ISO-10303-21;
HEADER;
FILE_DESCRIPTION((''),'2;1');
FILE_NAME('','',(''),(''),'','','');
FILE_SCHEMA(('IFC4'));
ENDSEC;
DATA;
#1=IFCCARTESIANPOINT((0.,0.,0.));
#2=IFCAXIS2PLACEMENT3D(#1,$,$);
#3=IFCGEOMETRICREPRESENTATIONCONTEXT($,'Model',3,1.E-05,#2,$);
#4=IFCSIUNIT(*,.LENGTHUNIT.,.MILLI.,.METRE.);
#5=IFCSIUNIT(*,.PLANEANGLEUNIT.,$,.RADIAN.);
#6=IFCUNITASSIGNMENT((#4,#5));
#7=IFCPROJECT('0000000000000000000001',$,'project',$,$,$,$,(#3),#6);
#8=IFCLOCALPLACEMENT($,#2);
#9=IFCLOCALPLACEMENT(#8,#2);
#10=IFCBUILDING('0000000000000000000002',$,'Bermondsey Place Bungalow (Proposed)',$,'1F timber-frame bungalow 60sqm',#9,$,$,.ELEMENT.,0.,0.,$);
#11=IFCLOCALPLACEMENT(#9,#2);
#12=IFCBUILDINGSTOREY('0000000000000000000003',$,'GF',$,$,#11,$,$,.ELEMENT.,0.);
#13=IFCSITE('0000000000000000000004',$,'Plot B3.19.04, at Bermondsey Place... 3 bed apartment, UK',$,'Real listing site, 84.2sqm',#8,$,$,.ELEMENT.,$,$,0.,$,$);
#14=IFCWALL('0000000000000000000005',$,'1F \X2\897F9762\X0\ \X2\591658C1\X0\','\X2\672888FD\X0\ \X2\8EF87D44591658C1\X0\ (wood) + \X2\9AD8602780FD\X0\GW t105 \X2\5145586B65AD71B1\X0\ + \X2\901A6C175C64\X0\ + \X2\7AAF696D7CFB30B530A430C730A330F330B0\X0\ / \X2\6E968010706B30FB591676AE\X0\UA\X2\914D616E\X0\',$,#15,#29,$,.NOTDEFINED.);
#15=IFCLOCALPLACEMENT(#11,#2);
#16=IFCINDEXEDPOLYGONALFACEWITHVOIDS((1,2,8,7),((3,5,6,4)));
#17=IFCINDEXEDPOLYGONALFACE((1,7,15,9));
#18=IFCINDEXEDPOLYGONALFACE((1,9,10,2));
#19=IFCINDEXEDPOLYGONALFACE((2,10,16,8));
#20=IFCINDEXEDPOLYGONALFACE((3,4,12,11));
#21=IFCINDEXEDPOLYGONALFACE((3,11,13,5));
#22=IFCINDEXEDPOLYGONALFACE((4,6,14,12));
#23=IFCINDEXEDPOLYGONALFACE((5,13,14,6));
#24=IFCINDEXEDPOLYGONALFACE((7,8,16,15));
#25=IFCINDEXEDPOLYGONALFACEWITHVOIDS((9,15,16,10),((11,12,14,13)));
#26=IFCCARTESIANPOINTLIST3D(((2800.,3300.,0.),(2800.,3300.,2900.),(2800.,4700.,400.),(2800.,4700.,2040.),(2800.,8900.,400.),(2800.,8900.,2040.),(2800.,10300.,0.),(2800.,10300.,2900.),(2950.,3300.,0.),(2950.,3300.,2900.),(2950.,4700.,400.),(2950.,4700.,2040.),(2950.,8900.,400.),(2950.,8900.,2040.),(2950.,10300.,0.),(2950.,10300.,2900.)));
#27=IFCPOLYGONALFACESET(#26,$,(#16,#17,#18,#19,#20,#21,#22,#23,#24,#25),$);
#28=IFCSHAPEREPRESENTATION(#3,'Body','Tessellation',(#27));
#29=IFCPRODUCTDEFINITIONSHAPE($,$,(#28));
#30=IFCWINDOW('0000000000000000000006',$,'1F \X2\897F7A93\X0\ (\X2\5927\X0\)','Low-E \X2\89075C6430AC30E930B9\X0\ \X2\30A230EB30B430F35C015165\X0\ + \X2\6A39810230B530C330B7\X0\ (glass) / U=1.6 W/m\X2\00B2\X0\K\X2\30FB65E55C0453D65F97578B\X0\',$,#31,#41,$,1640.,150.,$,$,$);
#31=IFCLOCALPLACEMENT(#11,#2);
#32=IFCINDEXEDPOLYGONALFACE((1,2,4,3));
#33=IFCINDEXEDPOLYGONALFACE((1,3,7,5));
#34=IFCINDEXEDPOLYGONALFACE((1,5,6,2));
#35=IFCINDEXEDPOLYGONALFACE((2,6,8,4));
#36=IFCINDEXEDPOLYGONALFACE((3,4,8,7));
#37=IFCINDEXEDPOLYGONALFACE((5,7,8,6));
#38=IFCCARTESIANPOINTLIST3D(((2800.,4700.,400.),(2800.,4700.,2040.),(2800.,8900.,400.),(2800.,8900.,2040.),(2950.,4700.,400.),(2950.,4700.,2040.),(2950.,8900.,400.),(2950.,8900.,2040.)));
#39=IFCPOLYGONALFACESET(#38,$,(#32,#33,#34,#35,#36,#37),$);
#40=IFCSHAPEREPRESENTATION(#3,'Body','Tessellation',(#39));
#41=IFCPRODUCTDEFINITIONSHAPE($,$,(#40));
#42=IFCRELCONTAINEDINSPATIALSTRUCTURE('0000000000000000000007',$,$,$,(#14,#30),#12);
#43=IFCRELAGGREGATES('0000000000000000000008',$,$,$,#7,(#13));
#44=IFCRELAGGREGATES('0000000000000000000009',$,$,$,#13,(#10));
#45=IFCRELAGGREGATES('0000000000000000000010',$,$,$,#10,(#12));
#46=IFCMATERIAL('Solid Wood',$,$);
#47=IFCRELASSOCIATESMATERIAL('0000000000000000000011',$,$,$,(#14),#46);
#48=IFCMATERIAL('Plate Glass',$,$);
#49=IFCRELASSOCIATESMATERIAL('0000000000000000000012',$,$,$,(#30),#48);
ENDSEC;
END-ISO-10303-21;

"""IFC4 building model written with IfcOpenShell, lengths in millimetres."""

from ifc_helpers import new_model, si_unit, frame, frame_2d, origin, place, context, project, spatial, rectangle, extrude, material, element, fill, save


model = new_model("IFC4")

# Units and contexts
model_context = context("Model", 3, precision=1e-05, world=origin())
ifc_project = project(units=[si_unit("LENGTHUNIT", "METRE", prefix="MILLI"), si_unit("PLANEANGLEUNIT", "RADIAN")], contexts=[model_context])

# Site, building, storey
site_placement = place(None, origin())
site = spatial("IfcSite", under=ifc_project, at=site_placement, Name="Plot B3.19.04, at Bermondsey Place... 3 bed apartment, UK", ObjectType="Real listing site, 84.2sqm", CompositionType="ELEMENT", RefElevation=0.0)
building_placement = place(site_placement, origin())
building = spatial("IfcBuilding", under=site, at=building_placement, Name="Bermondsey Place Bungalow (Proposed)", ObjectType="1F timber-frame bungalow 60sqm", CompositionType="ELEMENT", ElevationOfRefHeight=0.0, ElevationOfTerrain=0.0)
storey_placement = place(building_placement, origin())
storey = spatial("IfcBuildingStorey", under=building, at=storey_placement, Name="GF", CompositionType="ELEMENT", Elevation=0.0)

# Shared definitions
ifc_material_1 = material(Name="Solid Wood")

# Shared definitions
ifc_material_2 = material(Name="Plate Glass")

# Wall, opening, window
wall_1_placement = place(storey_placement, frame((1400.0, 1650.0, 0.0)))
wall_1 = element("IfcWall", 1, at=wall_1_placement, inside=storey, material=ifc_material_1, Name="1F 西面 外壁", Description="木製 軸組外壁 (wood) + 高性能GW t105 充填断熱 + 通気層 + 窯業系サイディング / 準耐火・外皮UA配慮", PredefinedType="NOTDEFINED", context=model_context, shape_type="SweptSolid", body=[
    extrude(rectangle(XDim=150.0, YDim=7000.0, at=frame_2d((75.0, 3500.0))), frame((1400.0, 1650.0, 0.0)), (0.0, 0.0, 1.0), 2900.0),
])
opening_1_placement = place(storey_placement, frame((1400.0, 2350.0, 200.0)))
opening_1 = element("IfcOpeningElement", 2, at=opening_1_placement, cuts=wall_1, PredefinedType="NOTDEFINED", context=model_context, shape_type="SweptSolid", body=[
    extrude(rectangle(XDim=150.0, YDim=4200.0, at=frame_2d((75.0, 2100.0))), frame((1400.0, 2350.0, 200.0)), (0.0, 0.0, 1.0), 1640.0),
])
window_1_placement = place(storey_placement, frame((1400.0, 2350.0, 200.0)))
window_1 = element("IfcWindow", 3, at=window_1_placement, inside=storey, material=ifc_material_2, Name="1F 西窓 (大)", Description="Low-E 複層ガラス アルゴン封入 + 樹脂サッシ (glass) / U=1.6 W/m²K・日射取得型", OverallHeight=1640.0, OverallWidth=150.0, context=model_context, shape_type="SweptSolid", body=[
    extrude(rectangle(XDim=150.0, YDim=4200.0, at=frame_2d((75.0, 2100.0))), frame((1400.0, 2350.0, 200.0)), (0.0, 0.0, 1.0), 1640.0),
])
fill(opening_1, window_1)

save(model, "model.ifc")
